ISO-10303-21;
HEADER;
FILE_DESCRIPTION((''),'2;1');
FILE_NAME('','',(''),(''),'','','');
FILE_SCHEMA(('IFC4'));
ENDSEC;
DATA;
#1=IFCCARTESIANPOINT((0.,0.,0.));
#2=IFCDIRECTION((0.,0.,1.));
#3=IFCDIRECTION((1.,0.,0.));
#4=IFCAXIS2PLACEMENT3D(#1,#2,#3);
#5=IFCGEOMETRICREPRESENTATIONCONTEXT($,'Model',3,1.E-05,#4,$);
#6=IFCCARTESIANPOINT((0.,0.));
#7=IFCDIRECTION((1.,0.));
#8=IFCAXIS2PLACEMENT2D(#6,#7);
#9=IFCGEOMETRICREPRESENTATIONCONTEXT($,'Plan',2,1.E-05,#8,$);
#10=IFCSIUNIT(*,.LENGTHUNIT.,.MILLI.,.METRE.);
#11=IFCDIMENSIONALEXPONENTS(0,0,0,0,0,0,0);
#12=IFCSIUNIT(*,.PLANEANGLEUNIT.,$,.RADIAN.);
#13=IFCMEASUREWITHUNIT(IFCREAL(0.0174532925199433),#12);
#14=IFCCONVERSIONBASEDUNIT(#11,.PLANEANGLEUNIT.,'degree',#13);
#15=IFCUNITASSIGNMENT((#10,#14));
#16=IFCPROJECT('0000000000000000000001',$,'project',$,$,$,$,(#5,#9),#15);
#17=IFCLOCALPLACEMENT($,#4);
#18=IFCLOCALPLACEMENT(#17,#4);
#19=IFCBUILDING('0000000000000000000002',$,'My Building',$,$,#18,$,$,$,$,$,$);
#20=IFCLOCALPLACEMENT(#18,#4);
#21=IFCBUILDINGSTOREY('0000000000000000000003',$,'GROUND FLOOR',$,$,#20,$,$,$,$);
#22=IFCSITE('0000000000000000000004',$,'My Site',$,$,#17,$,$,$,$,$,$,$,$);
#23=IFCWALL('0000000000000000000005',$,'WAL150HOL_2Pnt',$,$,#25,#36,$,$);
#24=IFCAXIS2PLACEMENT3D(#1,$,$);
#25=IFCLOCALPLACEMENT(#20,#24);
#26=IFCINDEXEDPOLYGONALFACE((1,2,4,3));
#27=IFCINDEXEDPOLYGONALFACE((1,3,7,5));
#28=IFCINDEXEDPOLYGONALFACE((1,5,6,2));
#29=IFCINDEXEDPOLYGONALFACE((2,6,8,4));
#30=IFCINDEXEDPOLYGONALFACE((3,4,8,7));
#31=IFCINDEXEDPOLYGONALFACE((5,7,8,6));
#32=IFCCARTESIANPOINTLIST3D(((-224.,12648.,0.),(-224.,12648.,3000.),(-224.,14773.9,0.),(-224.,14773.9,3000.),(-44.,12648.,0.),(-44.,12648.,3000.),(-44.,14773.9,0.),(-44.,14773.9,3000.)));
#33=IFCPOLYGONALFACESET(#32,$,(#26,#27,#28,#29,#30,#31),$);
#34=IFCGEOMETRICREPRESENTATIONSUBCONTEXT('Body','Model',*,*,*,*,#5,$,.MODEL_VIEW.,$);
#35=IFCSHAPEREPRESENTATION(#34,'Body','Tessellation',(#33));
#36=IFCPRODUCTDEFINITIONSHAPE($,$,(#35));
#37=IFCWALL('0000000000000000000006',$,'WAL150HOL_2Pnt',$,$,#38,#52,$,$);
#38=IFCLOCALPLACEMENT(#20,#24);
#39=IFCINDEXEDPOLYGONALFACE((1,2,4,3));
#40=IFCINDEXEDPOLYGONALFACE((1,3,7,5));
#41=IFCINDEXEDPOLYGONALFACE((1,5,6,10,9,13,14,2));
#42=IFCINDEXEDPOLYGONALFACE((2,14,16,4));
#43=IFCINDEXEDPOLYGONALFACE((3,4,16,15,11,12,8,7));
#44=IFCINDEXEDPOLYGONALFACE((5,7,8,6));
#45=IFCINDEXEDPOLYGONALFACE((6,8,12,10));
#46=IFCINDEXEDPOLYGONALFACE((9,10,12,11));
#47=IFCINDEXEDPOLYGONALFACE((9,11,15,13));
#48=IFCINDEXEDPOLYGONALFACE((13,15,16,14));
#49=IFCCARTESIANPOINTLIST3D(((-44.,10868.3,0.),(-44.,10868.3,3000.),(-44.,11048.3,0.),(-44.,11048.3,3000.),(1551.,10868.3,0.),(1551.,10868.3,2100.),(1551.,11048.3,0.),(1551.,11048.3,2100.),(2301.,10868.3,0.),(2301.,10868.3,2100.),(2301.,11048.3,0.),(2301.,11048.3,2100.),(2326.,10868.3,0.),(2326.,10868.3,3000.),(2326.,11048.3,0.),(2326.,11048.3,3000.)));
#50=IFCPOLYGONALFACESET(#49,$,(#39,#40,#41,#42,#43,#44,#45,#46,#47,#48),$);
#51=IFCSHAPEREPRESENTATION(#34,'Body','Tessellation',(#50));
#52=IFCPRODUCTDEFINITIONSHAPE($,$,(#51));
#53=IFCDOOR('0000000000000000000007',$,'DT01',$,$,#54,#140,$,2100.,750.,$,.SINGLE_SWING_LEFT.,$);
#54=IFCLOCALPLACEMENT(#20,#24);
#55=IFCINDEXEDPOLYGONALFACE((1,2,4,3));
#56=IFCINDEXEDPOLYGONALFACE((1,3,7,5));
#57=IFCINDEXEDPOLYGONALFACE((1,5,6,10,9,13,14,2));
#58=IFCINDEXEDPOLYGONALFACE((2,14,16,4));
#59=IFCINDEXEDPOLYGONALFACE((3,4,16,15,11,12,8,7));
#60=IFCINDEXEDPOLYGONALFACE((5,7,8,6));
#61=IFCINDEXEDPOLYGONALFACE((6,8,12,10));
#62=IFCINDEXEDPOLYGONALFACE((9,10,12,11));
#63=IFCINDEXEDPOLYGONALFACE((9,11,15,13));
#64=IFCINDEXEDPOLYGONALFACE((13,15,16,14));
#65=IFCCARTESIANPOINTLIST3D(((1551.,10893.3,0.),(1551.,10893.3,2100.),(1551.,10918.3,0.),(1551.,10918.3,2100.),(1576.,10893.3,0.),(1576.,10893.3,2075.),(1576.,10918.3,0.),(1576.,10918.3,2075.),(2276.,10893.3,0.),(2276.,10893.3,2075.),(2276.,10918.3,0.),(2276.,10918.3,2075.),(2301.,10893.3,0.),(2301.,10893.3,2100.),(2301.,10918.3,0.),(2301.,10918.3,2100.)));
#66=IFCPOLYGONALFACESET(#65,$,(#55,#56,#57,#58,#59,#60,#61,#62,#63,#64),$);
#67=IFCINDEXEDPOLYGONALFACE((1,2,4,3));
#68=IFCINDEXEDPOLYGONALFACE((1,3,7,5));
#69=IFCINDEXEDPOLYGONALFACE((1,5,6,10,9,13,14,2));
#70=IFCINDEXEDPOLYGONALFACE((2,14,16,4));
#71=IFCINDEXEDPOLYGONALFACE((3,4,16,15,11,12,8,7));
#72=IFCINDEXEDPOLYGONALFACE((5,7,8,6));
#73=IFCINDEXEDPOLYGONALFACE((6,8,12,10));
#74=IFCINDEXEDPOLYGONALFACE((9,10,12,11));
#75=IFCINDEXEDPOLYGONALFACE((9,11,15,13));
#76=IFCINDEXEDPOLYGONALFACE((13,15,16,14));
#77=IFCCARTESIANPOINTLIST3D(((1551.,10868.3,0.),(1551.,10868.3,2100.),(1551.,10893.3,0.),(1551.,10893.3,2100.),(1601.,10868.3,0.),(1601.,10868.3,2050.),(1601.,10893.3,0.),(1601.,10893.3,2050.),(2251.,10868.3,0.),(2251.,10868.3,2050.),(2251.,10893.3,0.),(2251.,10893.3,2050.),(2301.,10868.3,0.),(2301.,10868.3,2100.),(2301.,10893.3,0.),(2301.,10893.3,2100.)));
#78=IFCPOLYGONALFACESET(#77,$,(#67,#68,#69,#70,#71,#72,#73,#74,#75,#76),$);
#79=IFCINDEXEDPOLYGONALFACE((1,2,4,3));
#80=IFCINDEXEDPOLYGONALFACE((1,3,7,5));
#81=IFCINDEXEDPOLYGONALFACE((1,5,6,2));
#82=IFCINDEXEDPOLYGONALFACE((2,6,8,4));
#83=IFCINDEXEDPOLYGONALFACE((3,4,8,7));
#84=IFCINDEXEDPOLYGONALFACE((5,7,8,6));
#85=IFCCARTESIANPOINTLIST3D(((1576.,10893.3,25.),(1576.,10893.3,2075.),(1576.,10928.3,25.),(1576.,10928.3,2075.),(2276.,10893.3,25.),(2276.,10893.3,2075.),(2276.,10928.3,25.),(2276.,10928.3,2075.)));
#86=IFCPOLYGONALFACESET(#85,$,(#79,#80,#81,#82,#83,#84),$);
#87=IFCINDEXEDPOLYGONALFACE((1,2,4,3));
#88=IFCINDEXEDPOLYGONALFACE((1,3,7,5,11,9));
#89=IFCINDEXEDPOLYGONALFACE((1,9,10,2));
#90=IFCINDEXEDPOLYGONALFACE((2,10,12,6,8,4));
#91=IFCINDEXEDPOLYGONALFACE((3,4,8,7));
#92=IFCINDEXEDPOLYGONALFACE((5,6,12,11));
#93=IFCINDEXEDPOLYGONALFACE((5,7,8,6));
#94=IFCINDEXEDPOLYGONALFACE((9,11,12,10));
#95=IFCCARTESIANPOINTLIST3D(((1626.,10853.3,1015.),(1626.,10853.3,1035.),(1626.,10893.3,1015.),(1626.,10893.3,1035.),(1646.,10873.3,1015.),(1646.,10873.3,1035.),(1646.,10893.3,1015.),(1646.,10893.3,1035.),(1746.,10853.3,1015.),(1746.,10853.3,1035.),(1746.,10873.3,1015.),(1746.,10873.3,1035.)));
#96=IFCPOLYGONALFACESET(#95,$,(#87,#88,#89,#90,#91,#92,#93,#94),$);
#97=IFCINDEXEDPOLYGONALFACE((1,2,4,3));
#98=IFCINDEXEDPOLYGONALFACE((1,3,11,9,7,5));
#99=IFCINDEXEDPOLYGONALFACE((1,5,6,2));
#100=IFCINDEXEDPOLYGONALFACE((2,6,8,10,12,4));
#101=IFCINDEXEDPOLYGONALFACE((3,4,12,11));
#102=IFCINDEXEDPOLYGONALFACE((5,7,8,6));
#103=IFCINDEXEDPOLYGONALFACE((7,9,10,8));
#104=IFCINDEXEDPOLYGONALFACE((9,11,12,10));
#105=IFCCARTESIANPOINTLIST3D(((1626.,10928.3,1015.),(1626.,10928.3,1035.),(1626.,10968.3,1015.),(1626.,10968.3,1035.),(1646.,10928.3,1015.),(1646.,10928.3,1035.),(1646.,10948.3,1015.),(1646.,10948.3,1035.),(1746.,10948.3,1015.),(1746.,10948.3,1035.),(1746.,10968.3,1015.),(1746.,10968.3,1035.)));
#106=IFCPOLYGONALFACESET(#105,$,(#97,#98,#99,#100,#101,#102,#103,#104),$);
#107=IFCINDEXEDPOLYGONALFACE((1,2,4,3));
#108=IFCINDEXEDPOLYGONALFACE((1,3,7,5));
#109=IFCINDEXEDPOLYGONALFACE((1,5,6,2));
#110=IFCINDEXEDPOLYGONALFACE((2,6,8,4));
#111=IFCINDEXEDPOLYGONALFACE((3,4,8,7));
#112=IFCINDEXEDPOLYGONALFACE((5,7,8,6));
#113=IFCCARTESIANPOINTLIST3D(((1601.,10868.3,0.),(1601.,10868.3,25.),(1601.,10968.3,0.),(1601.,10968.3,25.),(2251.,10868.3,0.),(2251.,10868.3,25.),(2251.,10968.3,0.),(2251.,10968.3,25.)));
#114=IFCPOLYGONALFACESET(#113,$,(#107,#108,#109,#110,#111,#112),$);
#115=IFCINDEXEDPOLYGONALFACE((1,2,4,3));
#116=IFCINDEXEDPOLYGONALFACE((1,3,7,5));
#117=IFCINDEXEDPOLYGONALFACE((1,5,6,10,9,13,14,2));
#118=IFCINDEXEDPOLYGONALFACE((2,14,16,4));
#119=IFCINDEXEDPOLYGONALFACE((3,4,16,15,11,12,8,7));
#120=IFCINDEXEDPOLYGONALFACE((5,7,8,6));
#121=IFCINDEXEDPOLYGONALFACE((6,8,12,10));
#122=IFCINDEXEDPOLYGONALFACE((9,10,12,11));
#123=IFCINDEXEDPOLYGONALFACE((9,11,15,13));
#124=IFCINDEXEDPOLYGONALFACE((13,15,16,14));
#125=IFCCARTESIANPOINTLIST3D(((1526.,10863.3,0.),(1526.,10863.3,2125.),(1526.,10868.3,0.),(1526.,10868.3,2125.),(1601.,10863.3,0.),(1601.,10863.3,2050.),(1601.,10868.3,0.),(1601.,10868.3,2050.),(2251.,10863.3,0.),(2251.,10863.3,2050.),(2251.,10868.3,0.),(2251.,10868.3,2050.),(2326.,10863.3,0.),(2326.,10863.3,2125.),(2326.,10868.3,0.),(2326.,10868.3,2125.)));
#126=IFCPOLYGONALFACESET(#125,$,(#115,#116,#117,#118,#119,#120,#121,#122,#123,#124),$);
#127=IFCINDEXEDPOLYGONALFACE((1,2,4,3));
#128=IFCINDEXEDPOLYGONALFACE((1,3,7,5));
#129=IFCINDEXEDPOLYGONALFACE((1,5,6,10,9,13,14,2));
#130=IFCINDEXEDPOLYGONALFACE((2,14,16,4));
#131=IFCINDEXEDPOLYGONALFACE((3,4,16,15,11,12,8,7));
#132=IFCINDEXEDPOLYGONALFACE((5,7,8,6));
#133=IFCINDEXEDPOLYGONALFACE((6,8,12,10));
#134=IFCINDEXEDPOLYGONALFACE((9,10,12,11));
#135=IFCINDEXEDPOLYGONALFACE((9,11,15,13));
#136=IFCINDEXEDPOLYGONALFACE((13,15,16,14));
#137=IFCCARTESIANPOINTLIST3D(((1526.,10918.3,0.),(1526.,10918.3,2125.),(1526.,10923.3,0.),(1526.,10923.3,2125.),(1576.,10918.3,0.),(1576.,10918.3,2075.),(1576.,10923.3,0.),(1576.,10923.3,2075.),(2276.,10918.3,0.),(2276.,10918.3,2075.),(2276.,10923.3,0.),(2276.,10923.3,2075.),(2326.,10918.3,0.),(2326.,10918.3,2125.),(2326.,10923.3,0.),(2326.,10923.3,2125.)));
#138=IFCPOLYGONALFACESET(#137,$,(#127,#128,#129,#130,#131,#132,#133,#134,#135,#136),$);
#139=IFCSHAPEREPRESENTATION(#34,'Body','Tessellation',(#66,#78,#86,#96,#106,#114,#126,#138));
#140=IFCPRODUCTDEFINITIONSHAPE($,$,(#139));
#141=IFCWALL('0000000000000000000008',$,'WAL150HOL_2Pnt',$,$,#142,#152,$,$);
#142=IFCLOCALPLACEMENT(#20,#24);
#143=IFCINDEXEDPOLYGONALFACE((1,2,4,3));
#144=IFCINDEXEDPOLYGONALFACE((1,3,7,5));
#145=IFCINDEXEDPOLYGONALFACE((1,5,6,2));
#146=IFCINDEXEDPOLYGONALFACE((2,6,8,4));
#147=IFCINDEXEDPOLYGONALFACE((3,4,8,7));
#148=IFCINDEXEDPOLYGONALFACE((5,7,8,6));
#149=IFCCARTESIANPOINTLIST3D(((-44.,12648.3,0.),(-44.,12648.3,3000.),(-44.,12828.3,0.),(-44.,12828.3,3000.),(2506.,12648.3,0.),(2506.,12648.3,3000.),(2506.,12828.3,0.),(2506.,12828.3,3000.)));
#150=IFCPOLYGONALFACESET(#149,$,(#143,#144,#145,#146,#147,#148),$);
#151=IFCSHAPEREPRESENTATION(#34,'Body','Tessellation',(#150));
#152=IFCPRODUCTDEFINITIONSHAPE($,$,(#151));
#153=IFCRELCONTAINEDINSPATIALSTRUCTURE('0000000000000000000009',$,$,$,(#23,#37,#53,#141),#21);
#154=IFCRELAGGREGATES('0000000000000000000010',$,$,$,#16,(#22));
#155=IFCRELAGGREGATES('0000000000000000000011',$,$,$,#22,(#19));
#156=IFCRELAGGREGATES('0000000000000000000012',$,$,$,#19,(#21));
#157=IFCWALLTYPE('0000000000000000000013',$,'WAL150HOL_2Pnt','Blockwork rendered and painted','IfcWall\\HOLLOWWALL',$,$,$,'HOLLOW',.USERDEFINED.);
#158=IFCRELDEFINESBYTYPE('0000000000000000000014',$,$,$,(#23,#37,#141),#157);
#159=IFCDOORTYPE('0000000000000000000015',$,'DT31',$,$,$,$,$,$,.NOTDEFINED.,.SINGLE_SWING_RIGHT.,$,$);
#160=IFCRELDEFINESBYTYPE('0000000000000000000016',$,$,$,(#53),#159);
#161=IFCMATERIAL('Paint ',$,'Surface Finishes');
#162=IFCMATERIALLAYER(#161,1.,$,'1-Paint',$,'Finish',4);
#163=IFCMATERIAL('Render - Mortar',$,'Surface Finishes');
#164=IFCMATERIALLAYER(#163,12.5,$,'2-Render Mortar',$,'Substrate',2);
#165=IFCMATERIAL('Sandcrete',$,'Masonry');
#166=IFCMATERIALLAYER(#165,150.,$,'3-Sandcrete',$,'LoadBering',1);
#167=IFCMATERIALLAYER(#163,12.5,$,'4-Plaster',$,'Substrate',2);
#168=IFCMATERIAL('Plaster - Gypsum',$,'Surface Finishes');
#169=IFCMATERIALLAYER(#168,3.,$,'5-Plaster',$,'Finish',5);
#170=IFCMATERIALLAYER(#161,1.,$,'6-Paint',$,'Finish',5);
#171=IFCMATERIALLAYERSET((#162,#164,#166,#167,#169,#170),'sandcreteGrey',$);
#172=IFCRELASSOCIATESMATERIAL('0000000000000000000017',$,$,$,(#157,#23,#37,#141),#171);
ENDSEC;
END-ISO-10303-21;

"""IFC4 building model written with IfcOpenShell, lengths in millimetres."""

from ifc_helpers import new_model, entity, si_unit, converted_unit, frame, origin_with_axes, origin_2d_with_axis, place, context, subcontext, project, spatial, line, indexed_curve, outline, extrude, shape, source, transform, mapped, material, layer, layer_set, layer_usage, type_object, type_shapes, element, fill, save


model = new_model("IFC4")

# Units and contexts
model_context = context("Model", 3, precision=1e-05, world=origin_with_axes())
plan_context = context("Plan", 2, precision=1e-05, world=origin_2d_with_axis())
body_context_1 = subcontext(model_context, "Body", "Model", "MODEL_VIEW")
body_context_2 = subcontext(plan_context, "Body", "Plan", "PLAN_VIEW")
ifc_project = project(units=[si_unit("LENGTHUNIT", "METRE", prefix="MILLI"), converted_unit("PLANEANGLEUNIT", "degree", entity("IfcReal", 0.0174532925199433), si_unit("PLANEANGLEUNIT", "RADIAN"), dimensions=[0, 0, 0, 0, 0, 0, 0])], contexts=[model_context, plan_context])

# Site, building, storey
site_placement = place(None, origin_with_axes())
site = spatial("IfcSite", under=ifc_project, at=site_placement, Name="My Site")
building_placement = place(site_placement, origin_with_axes())
building = spatial("IfcBuilding", under=site, at=building_placement, Name="My Building")
storey_placement = place(building_placement, origin_with_axes())
storey = spatial("IfcBuildingStorey", under=building, at=storey_placement, Name="GROUND FLOOR")

# Wall
ifc_material_1 = material(Name="Paint ", Category="Surface Finishes")
ifc_layer_1 = layer(ifc_material_1, 1.0, Name="1-Paint", Category="Finish", Priority=4)
ifc_material_2 = material(Name="Render - Mortar", Category="Surface Finishes")
ifc_layer_2 = layer(ifc_material_2, 12.5, Name="2-Render Mortar", Category="Substrate", Priority=2)
ifc_material_3 = material(Name="Sandcrete", Category="Masonry")
ifc_layer_3 = layer(ifc_material_3, 150.0, Name="3-Sandcrete", Category="LoadBering", Priority=1)
ifc_layer_4 = layer(ifc_material_2, 12.5, Name="4-Plaster", Category="Substrate", Priority=2)
ifc_material_4 = material(Name="Plaster - Gypsum", Category="Surface Finishes")
ifc_layer_5 = layer(ifc_material_4, 3.0, Name="5-Plaster", Category="Finish", Priority=5)
ifc_layer_6 = layer(ifc_material_1, 1.0, Name="6-Paint", Category="Finish", Priority=5)
ifc_layer_set_1 = layer_set([ifc_layer_1, ifc_layer_2, ifc_layer_3, ifc_layer_4, ifc_layer_5, ifc_layer_6], Name="sandcreteGrey")
ifc_layer_usage_1 = layer_usage(ifc_layer_set_1, "AXIS2", "POSITIVE", 0.0)
wall_type_1 = type_object("IfcWallType", Name="WAL150HOL_2Pnt", Description="Blockwork rendered and painted", ApplicableOccurrence="IfcWall\\HOLLOWWALL", ElementType="HOLLOW", PredefinedType="USERDEFINED", material=ifc_layer_set_1)
wall_1_placement = place(storey_placement, frame((-224.0, 14773.9, 0.0), z_axis=(0.0, 0.0, 1.0), x_axis=(0.0, -1.0, 0.0)))
element("IfcWall", 1, at=wall_1_placement, inside=storey, type_object=wall_type_1, material=ifc_layer_usage_1, Name="WAL150HOL_2Pnt", context=body_context_1, shape_type="SweptSolid", body=[
    extrude(outline(indexed_curve([(0.0, 0.0), (0.0, 180.0), (2125.9, 180.0), (2125.9, 0.0), (0.0, 0.0)], self_intersect=False)), origin_with_axes(), (0.0, 0.0, 1.0), 3000.0),
])

# Wall, opening, door
ifc_layer_usage_2 = layer_usage(ifc_layer_set_1, "AXIS2", "POSITIVE", 0.0)
wall_2_placement = place(storey_placement, frame((-44.0, 10868.3, 0.0), z_axis=(0.0, 0.0, 1.0), x_axis=(1.0, -0.000002, 0.0)))
wall_2 = element("IfcWall", 2, at=wall_2_placement, inside=storey, type_object=wall_type_1, material=ifc_layer_usage_2, Name="WAL150HOL_2Pnt", context=body_context_1, shape_type="SweptSolid", body=[
    extrude(outline(indexed_curve([(0.0, 0.0), (0.0, 180.0), (2370.0, 180.0), (2370.0, 0.0), (0.0, 0.0)], self_intersect=False)), origin_with_axes(), (0.0, 0.0, 1.0), 3000.0),
])
shared_shape_1 = source(origin_with_axes(), body_context_1, "Body", "SweptSolid", [
    extrude(outline(indexed_curve([(0.0, 0.0), (750.0, 0.0), (750.0, 2100.0), (0.0, 2100.0)], segments=[line(1, 2, 3, 4, 1)])), frame((0.0, -600.0, 0.0), z_axis=(0.0, -1.0, 0.0), x_axis=(1.0, 0.0, 0.0)), (0.0, 0.0, -1.0), 1200.0),
])
opening_1_placement = place(wall_2_placement, frame((1595.0, 0.0, 0.0), z_axis=(0.0, 0.0, 1.0), x_axis=(1.0, 0.0, 0.0)))
opening_1 = element("IfcOpeningElement", 3, at=opening_1_placement, cuts=wall_2, PredefinedType="OPENING", context=body_context_1, shape_type="MappedRepresentation", body=[
    mapped(shared_shape_1, transform((0.0, 0.0, 0.0), x_axis=(1.0, 0.0, 0.0), y_axis=(0.0, 1.0, 0.0), z_axis=(0.0, 0.0, 1.0), scale=1.0)),
])
door_type_1 = type_object("IfcDoorType", Name="DT31", OperationType="SINGLE_SWING_RIGHT", PredefinedType="NOTDEFINED")
shared_shape_2 = source(origin_with_axes(), body_context_1, "Body", "SweptSolid", [
    extrude(outline(indexed_curve([(0.0, 0.0), (0.0, 2100.0), (750.0, 2100.0), (750.0, 0.0), (725.0, 0.0), (725.0, 2075.0), (25.0, 2075.0), (25.0, 0.0)], segments=[line(1, 2, 3, 4, 5, 6, 7, 8, 1)])), frame((0.0, 25.0, 0.0), z_axis=(0.0, -1.0, 0.0), x_axis=(1.0, 0.0, 0.0)), (0.0, 0.0, -1.0), 25.0),
    extrude(outline(indexed_curve([(0.0, 0.0), (0.0, 2100.0), (750.0, 2100.0), (750.0, 0.0), (700.0, 0.0), (700.0, 2050.0), (50.0, 2050.0), (50.0, 0.0)], segments=[line(1, 2, 3, 4, 5, 6, 7, 8, 1)])), frame((0.0, 0.0, 0.0), z_axis=(0.0, -1.0, 0.0), x_axis=(1.0, 0.0, 0.0)), (0.0, 0.0, -1.0), 25.0),
    extrude(outline(indexed_curve([(0.0, 0.0), (700.0, 0.0), (700.0, 35.0), (0.0, 35.0)], segments=[line(1, 2, 3, 4, 1)])), frame((25.0, 25.0, 25.0), z_axis=(0.0, 0.0, 1.0), x_axis=(1.0, 0.0, 0.0)), (0.0, 0.0, 1.0), 2050.0),
    extrude(outline(indexed_curve([(0.0, 0.0), (0.0, -40.0), (120.0, -40.0), (120.0, -20.0), (20.0, -20.0), (20.0, 0.0)], segments=[line(1, 2, 3, 4, 5, 6, 1)])), frame((75.0, 25.0, 1015.0), z_axis=(0.0, 0.0, 1.0), x_axis=(1.0, 0.0, 0.0)), (0.0, 0.0, 1.0), 20.0),
    extrude(outline(indexed_curve([(0.0, 0.0), (0.0, 40.0), (120.0, 40.0), (120.0, 20.0), (20.0, 20.0), (20.0, 0.0)], segments=[line(1, 2, 3, 4, 5, 6, 1)])), frame((75.0, 60.0, 1015.0), z_axis=(0.0, 0.0, 1.0), x_axis=(1.0, 0.0, 0.0)), (0.0, 0.0, 1.0), 20.0),
    extrude(outline(indexed_curve([(0.0, 0.0), (650.0, 0.0), (650.0, 100.0), (0.0, 100.0)], segments=[line(1, 2, 3, 4, 1)])), frame((50.0, 0.0, 0.0), z_axis=(0.0, 0.0, 1.0), x_axis=(1.0, 0.0, 0.0)), (0.0, 0.0, 1.0), 25.0),
    extrude(outline(indexed_curve([(0.0, 0.0), (0.0, 2125.0), (800.0, 2125.0), (800.0, 0.0), (725.0, 0.0), (725.0, 2050.0), (75.0, 2050.0), (75.0, 0.0)], segments=[line(1, 2, 3, 4, 5, 6, 7, 8, 1)])), frame((-25.0, -5.0, 0.0), z_axis=(0.0, -1.0, 0.0), x_axis=(1.0, 0.0, 0.0)), (0.0, 0.0, -1.0), 5.0),
    extrude(outline(indexed_curve([(0.0, 0.0), (0.0, 2125.0), (800.0, 2125.0), (800.0, 0.0), (750.0, 0.0), (750.0, 2075.0), (50.0, 2075.0), (50.0, 0.0)], segments=[line(1, 2, 3, 4, 5, 6, 7, 8, 1)])), frame((-25.0, 50.0, 0.0), z_axis=(0.0, -1.0, 0.0), x_axis=(1.0, 0.0, 0.0)), (0.0, 0.0, -1.0), 5.0),
])
shared_shape_3 = source(origin_with_axes(), body_context_2, "Body", "Curve2D", [
    entity("IfcIndexedPolyCurve", entity("IfcCartesianPointList2D", [[0.0, 0.0], [0.0, 50.0], [25.0, 50.0], [25.0, 25.0], [50.0, 25.0], [50.0, 0.0]]), [entity("IfcLineIndex", [1, 2, 3, 4, 5, 6, 1])]),
    entity("IfcIndexedPolyCurve", entity("IfcCartesianPointList2D", [[750.0, 0.0], [750.0, 50.0], [725.0, 50.0], [725.0, 25.0], [700.0, 25.0], [700.0, 0.0]]), [entity("IfcLineIndex", [1, 2, 3, 4, 5, 6, 1])]),
    entity("IfcTrimmedCurve", entity("IfcEllipse", entity("IfcAxis2Placement2D", entity("IfcCartesianPoint", [690.0, 50.0]), entity("IfcDirection", [1.0, 0.0])), 665.0, 700.0), [entity("IfcCartesianPoint", [690.0, 750.0])], [entity("IfcCartesianPoint", [25.0, 50.0])], True, "CARTESIAN"),
    entity("IfcIndexedPolyCurve", entity("IfcCartesianPointList2D", [[725.0, 50.0], [690.0, 50.0], [690.0, 750.0], [725.0, 750.0]]), [entity("IfcLineIndex", [1, 2, 3, 4, 1])]),
])
type_shapes(door_type_1, [shared_shape_2, shared_shape_3])
door_1_placement = place(opening_1_placement, origin_with_axes())
door_1 = element("IfcDoor", 4, at=door_1_placement, inside=storey, type_object=door_type_1, Name="DT01", OperationType="SINGLE_SWING_LEFT", OverallHeight=2100.0, OverallWidth=750.0, shapes=[
    shape(body_context_1, "Body", "MappedRepresentation", [mapped(shared_shape_2, transform((0.0, 0.0, 0.0), x_axis=(1.0, 0.0, 0.0), y_axis=(0.0, 1.0, 0.0), z_axis=(0.0, 0.0, 1.0), scale=1.0))]),
    shape(body_context_2, "Body", "MappedRepresentation", [mapped(shared_shape_3, transform((0.0, 0.0, 0.0), x_axis=(1.0, 0.0, 0.0), y_axis=(0.0, 1.0, 0.0), z_axis=(0.0, 0.0, 1.0), scale=1.0))]),
])
fill(opening_1, door_1)

# Wall
ifc_layer_usage_3 = layer_usage(ifc_layer_set_1, "AXIS2", "POSITIVE", 0.0)
wall_3_placement = place(storey_placement, frame((2506.0, 12828.3, 0.0), z_axis=(0.0, 0.0, 1.0), x_axis=(-1.0, 0.0, 0.0)))
element("IfcWall", 5, at=wall_3_placement, inside=storey, type_object=wall_type_1, material=ifc_layer_usage_3, Name="WAL150HOL_2Pnt", context=body_context_1, shape_type="SweptSolid", body=[
    extrude(outline(indexed_curve([(0.0, 0.0), (0.0, 180.0), (2550.0, 180.0), (2550.0, 0.0), (0.0, 0.0)], self_intersect=False)), origin_with_axes(), (0.0, 0.0, 1.0), 3000.0),
])

save(model, "model.ifc")
